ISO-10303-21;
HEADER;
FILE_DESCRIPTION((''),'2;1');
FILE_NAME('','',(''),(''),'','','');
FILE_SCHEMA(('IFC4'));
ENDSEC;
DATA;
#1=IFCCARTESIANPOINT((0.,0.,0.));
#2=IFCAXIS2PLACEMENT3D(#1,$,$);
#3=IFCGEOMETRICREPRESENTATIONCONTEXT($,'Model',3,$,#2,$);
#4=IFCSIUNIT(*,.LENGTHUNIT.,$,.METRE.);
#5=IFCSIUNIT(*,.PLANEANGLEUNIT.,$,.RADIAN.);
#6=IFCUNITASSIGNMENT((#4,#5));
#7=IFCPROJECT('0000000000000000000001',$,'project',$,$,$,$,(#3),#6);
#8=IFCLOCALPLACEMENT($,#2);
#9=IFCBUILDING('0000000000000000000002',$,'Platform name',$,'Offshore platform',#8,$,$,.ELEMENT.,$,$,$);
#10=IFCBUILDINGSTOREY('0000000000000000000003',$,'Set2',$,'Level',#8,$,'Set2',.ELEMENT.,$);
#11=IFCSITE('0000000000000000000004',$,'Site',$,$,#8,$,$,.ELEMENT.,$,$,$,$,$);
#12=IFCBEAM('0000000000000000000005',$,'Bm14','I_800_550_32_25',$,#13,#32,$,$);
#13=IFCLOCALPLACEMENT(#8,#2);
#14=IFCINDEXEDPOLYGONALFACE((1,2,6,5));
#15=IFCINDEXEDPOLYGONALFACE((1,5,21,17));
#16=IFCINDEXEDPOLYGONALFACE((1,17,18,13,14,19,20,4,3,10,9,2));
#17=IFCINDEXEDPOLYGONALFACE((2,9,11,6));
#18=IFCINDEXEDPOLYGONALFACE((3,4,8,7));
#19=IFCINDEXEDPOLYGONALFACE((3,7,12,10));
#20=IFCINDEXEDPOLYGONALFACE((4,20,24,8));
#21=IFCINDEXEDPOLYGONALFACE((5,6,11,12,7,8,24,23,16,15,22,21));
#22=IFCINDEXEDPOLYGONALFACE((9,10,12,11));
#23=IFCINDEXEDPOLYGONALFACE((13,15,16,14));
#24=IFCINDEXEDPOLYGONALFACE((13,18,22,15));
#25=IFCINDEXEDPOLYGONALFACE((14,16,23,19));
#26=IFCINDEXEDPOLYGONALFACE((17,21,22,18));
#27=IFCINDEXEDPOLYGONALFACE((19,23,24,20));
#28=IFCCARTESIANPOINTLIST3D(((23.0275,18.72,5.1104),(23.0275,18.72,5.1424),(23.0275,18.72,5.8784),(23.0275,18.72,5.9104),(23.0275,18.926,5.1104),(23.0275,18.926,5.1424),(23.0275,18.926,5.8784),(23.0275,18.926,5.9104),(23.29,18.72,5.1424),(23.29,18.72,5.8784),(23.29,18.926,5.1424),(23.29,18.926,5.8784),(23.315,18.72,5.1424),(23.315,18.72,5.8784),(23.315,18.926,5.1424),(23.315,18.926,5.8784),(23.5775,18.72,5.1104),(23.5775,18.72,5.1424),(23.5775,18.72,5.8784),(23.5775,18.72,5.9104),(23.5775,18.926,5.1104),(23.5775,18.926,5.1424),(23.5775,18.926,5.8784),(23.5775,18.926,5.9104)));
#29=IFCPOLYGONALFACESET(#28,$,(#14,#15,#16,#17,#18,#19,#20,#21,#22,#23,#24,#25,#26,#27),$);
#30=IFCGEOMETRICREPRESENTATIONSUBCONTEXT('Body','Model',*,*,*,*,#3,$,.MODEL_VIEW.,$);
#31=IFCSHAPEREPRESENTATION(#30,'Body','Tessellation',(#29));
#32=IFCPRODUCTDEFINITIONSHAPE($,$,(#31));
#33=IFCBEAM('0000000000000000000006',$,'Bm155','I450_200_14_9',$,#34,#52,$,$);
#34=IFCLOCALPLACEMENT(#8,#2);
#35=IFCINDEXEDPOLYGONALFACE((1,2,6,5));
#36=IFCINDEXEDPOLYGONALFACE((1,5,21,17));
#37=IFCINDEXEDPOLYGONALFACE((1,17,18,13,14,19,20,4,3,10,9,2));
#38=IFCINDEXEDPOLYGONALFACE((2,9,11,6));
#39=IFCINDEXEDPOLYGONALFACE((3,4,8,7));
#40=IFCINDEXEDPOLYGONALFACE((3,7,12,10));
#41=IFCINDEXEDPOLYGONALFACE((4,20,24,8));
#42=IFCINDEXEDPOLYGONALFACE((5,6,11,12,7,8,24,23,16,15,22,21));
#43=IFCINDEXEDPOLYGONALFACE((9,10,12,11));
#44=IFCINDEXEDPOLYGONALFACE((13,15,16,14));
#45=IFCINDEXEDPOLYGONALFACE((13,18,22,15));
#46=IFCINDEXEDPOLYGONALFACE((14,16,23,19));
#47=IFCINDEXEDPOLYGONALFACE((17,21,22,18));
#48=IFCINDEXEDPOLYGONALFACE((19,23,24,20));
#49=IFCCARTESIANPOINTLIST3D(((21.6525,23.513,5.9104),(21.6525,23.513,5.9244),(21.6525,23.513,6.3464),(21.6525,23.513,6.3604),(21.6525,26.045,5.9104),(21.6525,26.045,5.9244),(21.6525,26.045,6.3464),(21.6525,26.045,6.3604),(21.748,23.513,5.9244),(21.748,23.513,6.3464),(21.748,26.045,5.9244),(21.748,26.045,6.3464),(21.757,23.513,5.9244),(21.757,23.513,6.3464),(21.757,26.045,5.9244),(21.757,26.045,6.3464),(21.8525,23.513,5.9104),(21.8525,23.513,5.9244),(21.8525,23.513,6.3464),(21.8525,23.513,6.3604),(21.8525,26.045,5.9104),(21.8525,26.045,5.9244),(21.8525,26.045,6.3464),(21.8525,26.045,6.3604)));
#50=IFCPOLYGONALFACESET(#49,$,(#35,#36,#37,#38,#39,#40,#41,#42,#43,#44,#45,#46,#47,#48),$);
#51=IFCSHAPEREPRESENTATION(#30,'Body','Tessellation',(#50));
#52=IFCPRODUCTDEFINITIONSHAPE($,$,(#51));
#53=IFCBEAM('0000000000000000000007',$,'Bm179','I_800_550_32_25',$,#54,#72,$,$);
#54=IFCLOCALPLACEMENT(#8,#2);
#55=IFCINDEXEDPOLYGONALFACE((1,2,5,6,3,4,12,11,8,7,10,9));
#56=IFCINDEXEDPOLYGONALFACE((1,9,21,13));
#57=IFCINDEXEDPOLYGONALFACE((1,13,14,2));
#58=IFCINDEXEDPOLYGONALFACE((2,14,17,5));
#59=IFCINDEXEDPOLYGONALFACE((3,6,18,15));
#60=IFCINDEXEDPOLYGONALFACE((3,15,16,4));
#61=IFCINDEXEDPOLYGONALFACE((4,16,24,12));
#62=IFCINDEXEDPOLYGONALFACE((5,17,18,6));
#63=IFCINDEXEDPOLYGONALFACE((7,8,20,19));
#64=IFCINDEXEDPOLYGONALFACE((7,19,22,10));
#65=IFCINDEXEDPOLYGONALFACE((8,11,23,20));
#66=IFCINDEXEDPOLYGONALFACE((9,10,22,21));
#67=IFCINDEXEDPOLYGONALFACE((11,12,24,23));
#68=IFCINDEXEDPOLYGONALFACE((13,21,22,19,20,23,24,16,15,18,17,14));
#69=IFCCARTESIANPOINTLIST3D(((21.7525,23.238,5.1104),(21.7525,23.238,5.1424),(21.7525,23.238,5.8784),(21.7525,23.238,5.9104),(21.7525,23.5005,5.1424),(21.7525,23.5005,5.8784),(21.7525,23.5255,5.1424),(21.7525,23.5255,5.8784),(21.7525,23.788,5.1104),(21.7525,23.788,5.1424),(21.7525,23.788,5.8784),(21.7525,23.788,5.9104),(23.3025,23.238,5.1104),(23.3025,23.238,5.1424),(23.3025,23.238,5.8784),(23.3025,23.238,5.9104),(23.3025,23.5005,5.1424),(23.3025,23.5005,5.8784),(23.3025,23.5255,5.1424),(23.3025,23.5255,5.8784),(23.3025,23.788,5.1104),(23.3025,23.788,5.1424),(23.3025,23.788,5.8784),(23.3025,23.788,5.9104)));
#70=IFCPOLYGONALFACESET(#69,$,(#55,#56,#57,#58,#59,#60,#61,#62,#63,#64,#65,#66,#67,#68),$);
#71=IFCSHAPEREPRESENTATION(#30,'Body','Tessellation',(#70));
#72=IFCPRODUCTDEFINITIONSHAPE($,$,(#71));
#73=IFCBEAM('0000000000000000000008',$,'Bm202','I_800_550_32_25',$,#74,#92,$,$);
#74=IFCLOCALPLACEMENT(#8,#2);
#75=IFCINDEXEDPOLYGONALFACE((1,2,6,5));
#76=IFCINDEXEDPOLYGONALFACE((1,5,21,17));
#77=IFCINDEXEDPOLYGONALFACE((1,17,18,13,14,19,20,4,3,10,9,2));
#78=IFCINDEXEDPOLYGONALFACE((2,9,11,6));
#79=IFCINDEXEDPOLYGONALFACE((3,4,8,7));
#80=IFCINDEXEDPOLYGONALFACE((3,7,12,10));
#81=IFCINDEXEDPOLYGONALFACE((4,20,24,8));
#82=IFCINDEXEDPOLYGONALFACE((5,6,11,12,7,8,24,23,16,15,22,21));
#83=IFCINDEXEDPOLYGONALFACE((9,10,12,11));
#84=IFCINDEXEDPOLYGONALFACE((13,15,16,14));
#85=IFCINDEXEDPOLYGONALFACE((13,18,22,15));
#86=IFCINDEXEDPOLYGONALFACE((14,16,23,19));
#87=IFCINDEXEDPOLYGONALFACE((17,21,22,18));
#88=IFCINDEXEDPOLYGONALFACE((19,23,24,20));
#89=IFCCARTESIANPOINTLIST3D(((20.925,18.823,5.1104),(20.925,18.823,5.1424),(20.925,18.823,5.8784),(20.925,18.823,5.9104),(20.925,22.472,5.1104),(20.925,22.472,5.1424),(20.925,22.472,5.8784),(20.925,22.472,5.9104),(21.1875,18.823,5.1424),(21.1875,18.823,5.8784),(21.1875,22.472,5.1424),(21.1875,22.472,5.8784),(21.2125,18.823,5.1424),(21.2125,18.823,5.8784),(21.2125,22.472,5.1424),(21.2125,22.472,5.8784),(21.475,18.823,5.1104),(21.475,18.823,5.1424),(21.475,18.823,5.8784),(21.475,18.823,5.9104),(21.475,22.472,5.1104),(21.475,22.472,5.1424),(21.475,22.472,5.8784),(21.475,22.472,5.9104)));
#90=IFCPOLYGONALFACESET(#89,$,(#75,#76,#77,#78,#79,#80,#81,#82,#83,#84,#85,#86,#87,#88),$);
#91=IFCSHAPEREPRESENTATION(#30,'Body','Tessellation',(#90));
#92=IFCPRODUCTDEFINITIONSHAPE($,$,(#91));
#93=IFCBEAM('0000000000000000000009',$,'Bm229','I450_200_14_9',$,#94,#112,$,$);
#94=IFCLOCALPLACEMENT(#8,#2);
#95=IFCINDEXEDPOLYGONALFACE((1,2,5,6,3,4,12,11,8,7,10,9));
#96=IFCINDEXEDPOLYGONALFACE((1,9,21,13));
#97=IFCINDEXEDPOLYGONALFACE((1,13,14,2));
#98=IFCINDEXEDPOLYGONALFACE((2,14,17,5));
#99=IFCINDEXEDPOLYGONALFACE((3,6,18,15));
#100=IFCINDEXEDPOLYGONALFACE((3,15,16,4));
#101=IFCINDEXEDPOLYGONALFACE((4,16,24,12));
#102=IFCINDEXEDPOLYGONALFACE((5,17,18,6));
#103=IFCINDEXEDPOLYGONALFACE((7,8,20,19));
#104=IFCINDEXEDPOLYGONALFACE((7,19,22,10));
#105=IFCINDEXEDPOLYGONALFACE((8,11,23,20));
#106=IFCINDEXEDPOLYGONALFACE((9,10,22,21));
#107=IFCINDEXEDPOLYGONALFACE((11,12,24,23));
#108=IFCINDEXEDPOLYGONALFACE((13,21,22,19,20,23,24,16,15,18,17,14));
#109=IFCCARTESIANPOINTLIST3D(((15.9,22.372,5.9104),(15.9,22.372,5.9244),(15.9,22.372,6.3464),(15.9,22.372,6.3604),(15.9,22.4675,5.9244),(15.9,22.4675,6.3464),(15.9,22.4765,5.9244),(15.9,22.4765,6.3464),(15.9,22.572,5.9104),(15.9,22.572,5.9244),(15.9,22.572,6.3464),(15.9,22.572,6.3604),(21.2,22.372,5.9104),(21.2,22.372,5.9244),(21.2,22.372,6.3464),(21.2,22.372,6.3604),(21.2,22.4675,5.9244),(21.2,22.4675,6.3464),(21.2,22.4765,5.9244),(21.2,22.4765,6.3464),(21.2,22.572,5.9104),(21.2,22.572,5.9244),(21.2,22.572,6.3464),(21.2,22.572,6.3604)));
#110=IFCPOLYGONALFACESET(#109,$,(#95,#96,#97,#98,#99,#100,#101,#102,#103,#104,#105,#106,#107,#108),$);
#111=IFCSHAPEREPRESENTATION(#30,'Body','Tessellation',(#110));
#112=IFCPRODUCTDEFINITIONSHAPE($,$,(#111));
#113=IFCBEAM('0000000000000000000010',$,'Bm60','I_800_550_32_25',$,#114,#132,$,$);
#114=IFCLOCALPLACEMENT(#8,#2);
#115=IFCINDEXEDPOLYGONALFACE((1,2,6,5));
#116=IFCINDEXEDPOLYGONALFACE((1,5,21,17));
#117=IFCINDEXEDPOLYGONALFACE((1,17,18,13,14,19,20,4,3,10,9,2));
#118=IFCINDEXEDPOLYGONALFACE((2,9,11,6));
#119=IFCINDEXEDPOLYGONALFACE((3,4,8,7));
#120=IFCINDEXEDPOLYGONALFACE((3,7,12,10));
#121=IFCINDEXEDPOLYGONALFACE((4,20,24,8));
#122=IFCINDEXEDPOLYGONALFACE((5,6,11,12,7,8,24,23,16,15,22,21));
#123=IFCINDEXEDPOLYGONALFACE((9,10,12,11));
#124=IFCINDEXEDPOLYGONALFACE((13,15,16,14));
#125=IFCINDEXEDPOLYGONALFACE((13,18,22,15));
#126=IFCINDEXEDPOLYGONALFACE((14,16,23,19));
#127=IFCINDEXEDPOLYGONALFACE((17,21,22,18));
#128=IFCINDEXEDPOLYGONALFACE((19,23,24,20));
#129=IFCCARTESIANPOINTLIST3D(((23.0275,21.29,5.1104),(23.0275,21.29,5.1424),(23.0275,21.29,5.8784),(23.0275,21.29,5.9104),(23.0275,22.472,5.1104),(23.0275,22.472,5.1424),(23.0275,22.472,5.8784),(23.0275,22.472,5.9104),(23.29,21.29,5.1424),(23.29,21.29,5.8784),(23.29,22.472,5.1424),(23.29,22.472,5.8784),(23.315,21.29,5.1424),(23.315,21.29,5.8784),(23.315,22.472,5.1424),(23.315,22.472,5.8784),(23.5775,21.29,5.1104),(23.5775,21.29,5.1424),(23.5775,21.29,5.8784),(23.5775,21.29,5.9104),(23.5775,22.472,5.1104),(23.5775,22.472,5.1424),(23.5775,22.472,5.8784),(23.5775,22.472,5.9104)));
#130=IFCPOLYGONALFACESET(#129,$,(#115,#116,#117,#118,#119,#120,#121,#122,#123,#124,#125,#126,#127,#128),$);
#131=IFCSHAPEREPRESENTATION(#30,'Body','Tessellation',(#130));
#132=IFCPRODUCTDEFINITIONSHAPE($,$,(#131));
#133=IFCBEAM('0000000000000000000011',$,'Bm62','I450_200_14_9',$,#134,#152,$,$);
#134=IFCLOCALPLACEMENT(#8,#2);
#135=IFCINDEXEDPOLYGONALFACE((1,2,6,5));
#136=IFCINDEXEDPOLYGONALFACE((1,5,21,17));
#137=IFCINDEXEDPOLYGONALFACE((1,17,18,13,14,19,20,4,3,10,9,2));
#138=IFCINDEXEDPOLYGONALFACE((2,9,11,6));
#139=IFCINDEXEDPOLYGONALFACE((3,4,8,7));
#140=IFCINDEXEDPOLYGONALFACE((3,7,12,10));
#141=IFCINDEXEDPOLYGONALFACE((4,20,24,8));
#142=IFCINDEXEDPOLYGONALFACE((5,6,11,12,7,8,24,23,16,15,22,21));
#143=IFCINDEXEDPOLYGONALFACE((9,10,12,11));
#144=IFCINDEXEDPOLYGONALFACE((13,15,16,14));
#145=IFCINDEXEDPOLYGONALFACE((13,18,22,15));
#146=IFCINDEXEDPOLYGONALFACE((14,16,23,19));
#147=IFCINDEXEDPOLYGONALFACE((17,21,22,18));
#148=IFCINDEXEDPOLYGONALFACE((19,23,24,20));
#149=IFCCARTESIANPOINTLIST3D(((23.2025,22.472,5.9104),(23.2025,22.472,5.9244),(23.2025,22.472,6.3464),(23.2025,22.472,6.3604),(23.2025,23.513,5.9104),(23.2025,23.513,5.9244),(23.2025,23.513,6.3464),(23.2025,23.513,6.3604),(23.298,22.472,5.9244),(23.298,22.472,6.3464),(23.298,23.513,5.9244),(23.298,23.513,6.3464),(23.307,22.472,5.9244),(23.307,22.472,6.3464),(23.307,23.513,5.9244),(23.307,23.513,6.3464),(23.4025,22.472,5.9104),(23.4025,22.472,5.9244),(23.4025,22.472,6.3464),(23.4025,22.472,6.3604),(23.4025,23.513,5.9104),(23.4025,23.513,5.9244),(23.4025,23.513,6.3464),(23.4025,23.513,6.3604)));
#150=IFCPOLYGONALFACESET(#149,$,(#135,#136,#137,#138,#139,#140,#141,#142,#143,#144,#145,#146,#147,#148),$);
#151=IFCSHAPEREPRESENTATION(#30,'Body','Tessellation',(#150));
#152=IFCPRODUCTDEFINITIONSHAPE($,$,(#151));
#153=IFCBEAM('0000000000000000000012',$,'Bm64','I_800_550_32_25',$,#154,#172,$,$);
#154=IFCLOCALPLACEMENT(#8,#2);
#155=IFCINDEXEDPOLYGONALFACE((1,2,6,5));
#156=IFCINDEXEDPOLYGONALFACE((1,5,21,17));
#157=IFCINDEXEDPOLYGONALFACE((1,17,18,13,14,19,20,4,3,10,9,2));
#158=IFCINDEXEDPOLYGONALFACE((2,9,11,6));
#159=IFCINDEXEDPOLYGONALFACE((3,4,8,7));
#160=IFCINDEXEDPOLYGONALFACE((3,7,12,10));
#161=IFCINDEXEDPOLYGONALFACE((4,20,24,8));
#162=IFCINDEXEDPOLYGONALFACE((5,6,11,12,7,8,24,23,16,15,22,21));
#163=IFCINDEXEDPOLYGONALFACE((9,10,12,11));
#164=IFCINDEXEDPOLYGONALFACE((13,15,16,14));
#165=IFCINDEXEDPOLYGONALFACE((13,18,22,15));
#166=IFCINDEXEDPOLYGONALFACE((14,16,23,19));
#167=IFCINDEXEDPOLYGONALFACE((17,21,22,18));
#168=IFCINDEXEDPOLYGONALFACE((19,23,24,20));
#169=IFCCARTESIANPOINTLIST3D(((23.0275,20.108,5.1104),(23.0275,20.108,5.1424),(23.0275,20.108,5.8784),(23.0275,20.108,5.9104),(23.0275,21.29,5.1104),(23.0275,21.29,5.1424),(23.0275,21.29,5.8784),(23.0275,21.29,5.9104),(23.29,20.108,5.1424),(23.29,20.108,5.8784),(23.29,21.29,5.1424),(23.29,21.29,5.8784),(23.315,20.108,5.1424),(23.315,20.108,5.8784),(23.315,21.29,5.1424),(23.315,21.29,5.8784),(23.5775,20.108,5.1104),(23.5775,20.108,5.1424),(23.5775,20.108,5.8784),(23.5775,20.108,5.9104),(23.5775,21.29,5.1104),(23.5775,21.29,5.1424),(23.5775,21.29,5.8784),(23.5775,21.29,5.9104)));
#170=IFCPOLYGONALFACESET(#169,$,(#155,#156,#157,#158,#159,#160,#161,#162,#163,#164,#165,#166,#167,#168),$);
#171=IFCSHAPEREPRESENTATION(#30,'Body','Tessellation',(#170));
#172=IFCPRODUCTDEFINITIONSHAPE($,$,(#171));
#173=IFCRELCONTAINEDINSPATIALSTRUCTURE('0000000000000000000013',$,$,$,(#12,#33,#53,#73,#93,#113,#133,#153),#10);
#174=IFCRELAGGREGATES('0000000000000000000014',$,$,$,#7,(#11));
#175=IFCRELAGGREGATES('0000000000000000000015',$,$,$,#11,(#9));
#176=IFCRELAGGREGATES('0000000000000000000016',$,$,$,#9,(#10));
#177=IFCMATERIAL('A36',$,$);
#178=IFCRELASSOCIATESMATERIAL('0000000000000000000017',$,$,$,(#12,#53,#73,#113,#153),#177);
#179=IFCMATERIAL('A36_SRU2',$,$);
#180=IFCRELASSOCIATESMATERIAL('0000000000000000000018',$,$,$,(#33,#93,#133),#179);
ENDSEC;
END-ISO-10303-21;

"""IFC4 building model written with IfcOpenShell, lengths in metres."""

from ifc_helpers import new_model, si_unit, frame, origin, origin_2d, place, context, subcontext, project, spatial, i_section, extrude, source, transform, mapped, material, element, save


model = new_model("IFC4")

# Units and contexts
model_context = context("Model", 3, world=origin())
body_context = subcontext(model_context, "Body", "Model", "MODEL_VIEW")
ifc_project = project(units=[si_unit("LENGTHUNIT", "METRE"), si_unit("PLANEANGLEUNIT", "RADIAN")], contexts=[model_context])

# Site, building, storey
placement_1 = place(None, origin())
site = spatial("IfcSite", under=ifc_project, at=placement_1, Name="Site", CompositionType="ELEMENT")
building = spatial("IfcBuilding", under=site, at=placement_1, Name="Platform name", ObjectType="Offshore platform", CompositionType="ELEMENT")
storey = spatial("IfcBuildingStorey", under=building, at=placement_1, Name="Set2", ObjectType="Level", LongName="Set2", CompositionType="ELEMENT")

# Beams
ifc_material_1 = material(Name="A36_SRU2")
ifc_material_2 = material(Name="A36")
shared_shape_1 = source(origin(), body_context, "Body", "SweptSolid", [
    extrude(i_section(OverallWidth=0.55, OverallDepth=0.8, WebThickness=0.025, FlangeThickness=0.032, FilletRadius=0.0, at=origin_2d()), frame((0.0, 0.0, 0.0), z_axis=(0.0, -1.0, 0.0), x_axis=(1.0, 0.0, 0.0)), (0.0, 0.0, 1.0), 0.206),
])
placement_2 = place(None, origin())
placement_3 = place(placement_2, origin())
placement_4 = place(placement_3, origin())
beam_1_placement = place(placement_4, frame((23.3025, 18.926, 5.5104)))
element("IfcBeam", 1, at=beam_1_placement, inside=storey, material=ifc_material_2, Name="Bm14", Description="I_800_550_32_25", context=body_context, shape_type="MappedRepresentation", body=[
    mapped(shared_shape_1, transform((0.0, 0.0, 0.0), scale=1.0)),
])
shared_shape_2 = source(origin(), body_context, "Body", "SweptSolid", [
    extrude(i_section(OverallWidth=0.2, OverallDepth=0.45, WebThickness=0.009, FlangeThickness=0.014, FilletRadius=0.0, at=origin_2d()), frame((0.0, 0.0, 0.0), z_axis=(0.0, 1.0, 0.0), x_axis=(-1.0, 0.0, 0.0)), (0.0, 0.0, 1.0), 2.532),
])
placement_5 = place(None, origin())
placement_6 = place(placement_5, origin())
placement_7 = place(placement_6, origin())
beam_2_placement = place(placement_7, frame((21.7525, 23.513, 6.1354)))
element("IfcBeam", 2, at=beam_2_placement, inside=storey, material=ifc_material_1, Name="Bm155", Description="I450_200_14_9", context=body_context, shape_type="MappedRepresentation", body=[
    mapped(shared_shape_2, transform((0.0, 0.0, 0.0), scale=1.0)),
])
shared_shape_3 = source(origin(), body_context, "Body", "SweptSolid", [
    extrude(i_section(OverallWidth=0.55, OverallDepth=0.8, WebThickness=0.025, FlangeThickness=0.032, FilletRadius=0.0, at=origin_2d()), frame((0.0, 0.0, 0.0), z_axis=(1.0, 0.0, 0.0), x_axis=(0.0, 1.0, 0.0)), (0.0, 0.0, 1.0), 1.55),
])
placement_8 = place(None, origin())
placement_9 = place(placement_8, origin())
placement_10 = place(placement_9, origin())
beam_3_placement = place(placement_10, frame((21.7525, 23.513, 5.5104)))
element("IfcBeam", 3, at=beam_3_placement, inside=storey, material=ifc_material_2, Name="Bm179", Description="I_800_550_32_25", context=body_context, shape_type="MappedRepresentation", body=[
    mapped(shared_shape_3, transform((0.0, 0.0, 0.0), scale=1.0)),
])
shared_shape_4 = source(origin(), body_context, "Body", "SweptSolid", [
    extrude(i_section(OverallWidth=0.55, OverallDepth=0.8, WebThickness=0.025, FlangeThickness=0.032, FilletRadius=0.0, at=origin_2d()), frame((0.0, 0.0, 0.0), z_axis=(0.0, -1.0, 0.0), x_axis=(1.0, 0.0, 0.0)), (0.0, 0.0, 1.0), 3.649),
])
placement_11 = place(None, origin())
placement_12 = place(placement_11, origin())
placement_13 = place(placement_12, origin())
beam_4_placement = place(placement_13, frame((21.2, 22.472, 5.5104)))
element("IfcBeam", 4, at=beam_4_placement, inside=storey, material=ifc_material_2, Name="Bm202", Description="I_800_550_32_25", context=body_context, shape_type="MappedRepresentation", body=[
    mapped(shared_shape_4, transform((0.0, 0.0, 0.0), scale=1.0)),
])
shared_shape_5 = source(origin(), body_context, "Body", "SweptSolid", [
    extrude(i_section(OverallWidth=0.2, OverallDepth=0.45, WebThickness=0.009, FlangeThickness=0.014, FilletRadius=0.0, at=origin_2d()), frame((0.0, 0.0, 0.0), z_axis=(-1.0, 0.0, 0.0), x_axis=(0.0, -1.0, 0.0)), (0.0, 0.0, 1.0), 5.3),
])
placement_14 = place(None, origin())
placement_15 = place(placement_14, origin())
placement_16 = place(placement_15, origin())
beam_5_placement = place(placement_16, frame((21.2, 22.472, 6.1354)))
element("IfcBeam", 5, at=beam_5_placement, inside=storey, material=ifc_material_1, Name="Bm229", Description="I450_200_14_9", context=body_context, shape_type="MappedRepresentation", body=[
    mapped(shared_shape_5, transform((0.0, 0.0, 0.0), scale=1.0)),
])
shared_shape_6 = source(origin(), body_context, "Body", "SweptSolid", [
    extrude(i_section(OverallWidth=0.55, OverallDepth=0.8, WebThickness=0.025, FlangeThickness=0.032, FilletRadius=0.0, at=origin_2d()), frame((0.0, 0.0, 0.0), z_axis=(0.0, -1.0, 0.0), x_axis=(1.0, 0.0, 0.0)), (0.0, 0.0, 1.0), 1.182),
])
placement_17 = place(None, origin())
placement_18 = place(placement_17, origin())
placement_19 = place(placement_18, origin())
beam_6_placement = place(placement_19, frame((23.3025, 22.472, 5.5104)))
element("IfcBeam", 6, at=beam_6_placement, inside=storey, material=ifc_material_2, Name="Bm60", Description="I_800_550_32_25", context=body_context, shape_type="MappedRepresentation", body=[
    mapped(shared_shape_6, transform((0.0, 0.0, 0.0), scale=1.0)),
])
shared_shape_7 = source(origin(), body_context, "Body", "SweptSolid", [
    extrude(i_section(OverallWidth=0.2, OverallDepth=0.45, WebThickness=0.009, FlangeThickness=0.014, FilletRadius=0.0, at=origin_2d()), frame((0.0, 0.0, 0.0), z_axis=(0.0, 1.0, 0.0), x_axis=(-1.0, 0.0, 0.0)), (0.0, 0.0, 1.0), 1.041),
])
placement_20 = place(None, origin())
placement_21 = place(placement_20, origin())
placement_22 = place(placement_21, origin())
beam_7_placement = place(placement_22, frame((23.3025, 22.472, 6.1354)))
element("IfcBeam", 7, at=beam_7_placement, inside=storey, material=ifc_material_1, Name="Bm62", Description="I450_200_14_9", context=body_context, shape_type="MappedRepresentation", body=[
    mapped(shared_shape_7, transform((0.0, 0.0, 0.0), scale=1.0)),
])
shared_shape_8 = source(origin(), body_context, "Body", "SweptSolid", [
    extrude(i_section(OverallWidth=0.55, OverallDepth=0.8, WebThickness=0.025, FlangeThickness=0.032, FilletRadius=0.0, at=origin_2d()), frame((0.0, 0.0, 0.0), z_axis=(0.0, -1.0, 0.0), x_axis=(1.0, 0.0, 0.0)), (0.0, 0.0, 1.0), 1.182),
])
placement_23 = place(None, origin())
placement_24 = place(placement_23, origin())
placement_25 = place(placement_24, origin())
beam_8_placement = place(placement_25, frame((23.3025, 21.29, 5.5104)))
element("IfcBeam", 8, at=beam_8_placement, inside=storey, material=ifc_material_2, Name="Bm64", Description="I_800_550_32_25", context=body_context, shape_type="MappedRepresentation", body=[
    mapped(shared_shape_8, transform((0.0, 0.0, 0.0), scale=1.0)),
])

save(model, "model.ifc")
